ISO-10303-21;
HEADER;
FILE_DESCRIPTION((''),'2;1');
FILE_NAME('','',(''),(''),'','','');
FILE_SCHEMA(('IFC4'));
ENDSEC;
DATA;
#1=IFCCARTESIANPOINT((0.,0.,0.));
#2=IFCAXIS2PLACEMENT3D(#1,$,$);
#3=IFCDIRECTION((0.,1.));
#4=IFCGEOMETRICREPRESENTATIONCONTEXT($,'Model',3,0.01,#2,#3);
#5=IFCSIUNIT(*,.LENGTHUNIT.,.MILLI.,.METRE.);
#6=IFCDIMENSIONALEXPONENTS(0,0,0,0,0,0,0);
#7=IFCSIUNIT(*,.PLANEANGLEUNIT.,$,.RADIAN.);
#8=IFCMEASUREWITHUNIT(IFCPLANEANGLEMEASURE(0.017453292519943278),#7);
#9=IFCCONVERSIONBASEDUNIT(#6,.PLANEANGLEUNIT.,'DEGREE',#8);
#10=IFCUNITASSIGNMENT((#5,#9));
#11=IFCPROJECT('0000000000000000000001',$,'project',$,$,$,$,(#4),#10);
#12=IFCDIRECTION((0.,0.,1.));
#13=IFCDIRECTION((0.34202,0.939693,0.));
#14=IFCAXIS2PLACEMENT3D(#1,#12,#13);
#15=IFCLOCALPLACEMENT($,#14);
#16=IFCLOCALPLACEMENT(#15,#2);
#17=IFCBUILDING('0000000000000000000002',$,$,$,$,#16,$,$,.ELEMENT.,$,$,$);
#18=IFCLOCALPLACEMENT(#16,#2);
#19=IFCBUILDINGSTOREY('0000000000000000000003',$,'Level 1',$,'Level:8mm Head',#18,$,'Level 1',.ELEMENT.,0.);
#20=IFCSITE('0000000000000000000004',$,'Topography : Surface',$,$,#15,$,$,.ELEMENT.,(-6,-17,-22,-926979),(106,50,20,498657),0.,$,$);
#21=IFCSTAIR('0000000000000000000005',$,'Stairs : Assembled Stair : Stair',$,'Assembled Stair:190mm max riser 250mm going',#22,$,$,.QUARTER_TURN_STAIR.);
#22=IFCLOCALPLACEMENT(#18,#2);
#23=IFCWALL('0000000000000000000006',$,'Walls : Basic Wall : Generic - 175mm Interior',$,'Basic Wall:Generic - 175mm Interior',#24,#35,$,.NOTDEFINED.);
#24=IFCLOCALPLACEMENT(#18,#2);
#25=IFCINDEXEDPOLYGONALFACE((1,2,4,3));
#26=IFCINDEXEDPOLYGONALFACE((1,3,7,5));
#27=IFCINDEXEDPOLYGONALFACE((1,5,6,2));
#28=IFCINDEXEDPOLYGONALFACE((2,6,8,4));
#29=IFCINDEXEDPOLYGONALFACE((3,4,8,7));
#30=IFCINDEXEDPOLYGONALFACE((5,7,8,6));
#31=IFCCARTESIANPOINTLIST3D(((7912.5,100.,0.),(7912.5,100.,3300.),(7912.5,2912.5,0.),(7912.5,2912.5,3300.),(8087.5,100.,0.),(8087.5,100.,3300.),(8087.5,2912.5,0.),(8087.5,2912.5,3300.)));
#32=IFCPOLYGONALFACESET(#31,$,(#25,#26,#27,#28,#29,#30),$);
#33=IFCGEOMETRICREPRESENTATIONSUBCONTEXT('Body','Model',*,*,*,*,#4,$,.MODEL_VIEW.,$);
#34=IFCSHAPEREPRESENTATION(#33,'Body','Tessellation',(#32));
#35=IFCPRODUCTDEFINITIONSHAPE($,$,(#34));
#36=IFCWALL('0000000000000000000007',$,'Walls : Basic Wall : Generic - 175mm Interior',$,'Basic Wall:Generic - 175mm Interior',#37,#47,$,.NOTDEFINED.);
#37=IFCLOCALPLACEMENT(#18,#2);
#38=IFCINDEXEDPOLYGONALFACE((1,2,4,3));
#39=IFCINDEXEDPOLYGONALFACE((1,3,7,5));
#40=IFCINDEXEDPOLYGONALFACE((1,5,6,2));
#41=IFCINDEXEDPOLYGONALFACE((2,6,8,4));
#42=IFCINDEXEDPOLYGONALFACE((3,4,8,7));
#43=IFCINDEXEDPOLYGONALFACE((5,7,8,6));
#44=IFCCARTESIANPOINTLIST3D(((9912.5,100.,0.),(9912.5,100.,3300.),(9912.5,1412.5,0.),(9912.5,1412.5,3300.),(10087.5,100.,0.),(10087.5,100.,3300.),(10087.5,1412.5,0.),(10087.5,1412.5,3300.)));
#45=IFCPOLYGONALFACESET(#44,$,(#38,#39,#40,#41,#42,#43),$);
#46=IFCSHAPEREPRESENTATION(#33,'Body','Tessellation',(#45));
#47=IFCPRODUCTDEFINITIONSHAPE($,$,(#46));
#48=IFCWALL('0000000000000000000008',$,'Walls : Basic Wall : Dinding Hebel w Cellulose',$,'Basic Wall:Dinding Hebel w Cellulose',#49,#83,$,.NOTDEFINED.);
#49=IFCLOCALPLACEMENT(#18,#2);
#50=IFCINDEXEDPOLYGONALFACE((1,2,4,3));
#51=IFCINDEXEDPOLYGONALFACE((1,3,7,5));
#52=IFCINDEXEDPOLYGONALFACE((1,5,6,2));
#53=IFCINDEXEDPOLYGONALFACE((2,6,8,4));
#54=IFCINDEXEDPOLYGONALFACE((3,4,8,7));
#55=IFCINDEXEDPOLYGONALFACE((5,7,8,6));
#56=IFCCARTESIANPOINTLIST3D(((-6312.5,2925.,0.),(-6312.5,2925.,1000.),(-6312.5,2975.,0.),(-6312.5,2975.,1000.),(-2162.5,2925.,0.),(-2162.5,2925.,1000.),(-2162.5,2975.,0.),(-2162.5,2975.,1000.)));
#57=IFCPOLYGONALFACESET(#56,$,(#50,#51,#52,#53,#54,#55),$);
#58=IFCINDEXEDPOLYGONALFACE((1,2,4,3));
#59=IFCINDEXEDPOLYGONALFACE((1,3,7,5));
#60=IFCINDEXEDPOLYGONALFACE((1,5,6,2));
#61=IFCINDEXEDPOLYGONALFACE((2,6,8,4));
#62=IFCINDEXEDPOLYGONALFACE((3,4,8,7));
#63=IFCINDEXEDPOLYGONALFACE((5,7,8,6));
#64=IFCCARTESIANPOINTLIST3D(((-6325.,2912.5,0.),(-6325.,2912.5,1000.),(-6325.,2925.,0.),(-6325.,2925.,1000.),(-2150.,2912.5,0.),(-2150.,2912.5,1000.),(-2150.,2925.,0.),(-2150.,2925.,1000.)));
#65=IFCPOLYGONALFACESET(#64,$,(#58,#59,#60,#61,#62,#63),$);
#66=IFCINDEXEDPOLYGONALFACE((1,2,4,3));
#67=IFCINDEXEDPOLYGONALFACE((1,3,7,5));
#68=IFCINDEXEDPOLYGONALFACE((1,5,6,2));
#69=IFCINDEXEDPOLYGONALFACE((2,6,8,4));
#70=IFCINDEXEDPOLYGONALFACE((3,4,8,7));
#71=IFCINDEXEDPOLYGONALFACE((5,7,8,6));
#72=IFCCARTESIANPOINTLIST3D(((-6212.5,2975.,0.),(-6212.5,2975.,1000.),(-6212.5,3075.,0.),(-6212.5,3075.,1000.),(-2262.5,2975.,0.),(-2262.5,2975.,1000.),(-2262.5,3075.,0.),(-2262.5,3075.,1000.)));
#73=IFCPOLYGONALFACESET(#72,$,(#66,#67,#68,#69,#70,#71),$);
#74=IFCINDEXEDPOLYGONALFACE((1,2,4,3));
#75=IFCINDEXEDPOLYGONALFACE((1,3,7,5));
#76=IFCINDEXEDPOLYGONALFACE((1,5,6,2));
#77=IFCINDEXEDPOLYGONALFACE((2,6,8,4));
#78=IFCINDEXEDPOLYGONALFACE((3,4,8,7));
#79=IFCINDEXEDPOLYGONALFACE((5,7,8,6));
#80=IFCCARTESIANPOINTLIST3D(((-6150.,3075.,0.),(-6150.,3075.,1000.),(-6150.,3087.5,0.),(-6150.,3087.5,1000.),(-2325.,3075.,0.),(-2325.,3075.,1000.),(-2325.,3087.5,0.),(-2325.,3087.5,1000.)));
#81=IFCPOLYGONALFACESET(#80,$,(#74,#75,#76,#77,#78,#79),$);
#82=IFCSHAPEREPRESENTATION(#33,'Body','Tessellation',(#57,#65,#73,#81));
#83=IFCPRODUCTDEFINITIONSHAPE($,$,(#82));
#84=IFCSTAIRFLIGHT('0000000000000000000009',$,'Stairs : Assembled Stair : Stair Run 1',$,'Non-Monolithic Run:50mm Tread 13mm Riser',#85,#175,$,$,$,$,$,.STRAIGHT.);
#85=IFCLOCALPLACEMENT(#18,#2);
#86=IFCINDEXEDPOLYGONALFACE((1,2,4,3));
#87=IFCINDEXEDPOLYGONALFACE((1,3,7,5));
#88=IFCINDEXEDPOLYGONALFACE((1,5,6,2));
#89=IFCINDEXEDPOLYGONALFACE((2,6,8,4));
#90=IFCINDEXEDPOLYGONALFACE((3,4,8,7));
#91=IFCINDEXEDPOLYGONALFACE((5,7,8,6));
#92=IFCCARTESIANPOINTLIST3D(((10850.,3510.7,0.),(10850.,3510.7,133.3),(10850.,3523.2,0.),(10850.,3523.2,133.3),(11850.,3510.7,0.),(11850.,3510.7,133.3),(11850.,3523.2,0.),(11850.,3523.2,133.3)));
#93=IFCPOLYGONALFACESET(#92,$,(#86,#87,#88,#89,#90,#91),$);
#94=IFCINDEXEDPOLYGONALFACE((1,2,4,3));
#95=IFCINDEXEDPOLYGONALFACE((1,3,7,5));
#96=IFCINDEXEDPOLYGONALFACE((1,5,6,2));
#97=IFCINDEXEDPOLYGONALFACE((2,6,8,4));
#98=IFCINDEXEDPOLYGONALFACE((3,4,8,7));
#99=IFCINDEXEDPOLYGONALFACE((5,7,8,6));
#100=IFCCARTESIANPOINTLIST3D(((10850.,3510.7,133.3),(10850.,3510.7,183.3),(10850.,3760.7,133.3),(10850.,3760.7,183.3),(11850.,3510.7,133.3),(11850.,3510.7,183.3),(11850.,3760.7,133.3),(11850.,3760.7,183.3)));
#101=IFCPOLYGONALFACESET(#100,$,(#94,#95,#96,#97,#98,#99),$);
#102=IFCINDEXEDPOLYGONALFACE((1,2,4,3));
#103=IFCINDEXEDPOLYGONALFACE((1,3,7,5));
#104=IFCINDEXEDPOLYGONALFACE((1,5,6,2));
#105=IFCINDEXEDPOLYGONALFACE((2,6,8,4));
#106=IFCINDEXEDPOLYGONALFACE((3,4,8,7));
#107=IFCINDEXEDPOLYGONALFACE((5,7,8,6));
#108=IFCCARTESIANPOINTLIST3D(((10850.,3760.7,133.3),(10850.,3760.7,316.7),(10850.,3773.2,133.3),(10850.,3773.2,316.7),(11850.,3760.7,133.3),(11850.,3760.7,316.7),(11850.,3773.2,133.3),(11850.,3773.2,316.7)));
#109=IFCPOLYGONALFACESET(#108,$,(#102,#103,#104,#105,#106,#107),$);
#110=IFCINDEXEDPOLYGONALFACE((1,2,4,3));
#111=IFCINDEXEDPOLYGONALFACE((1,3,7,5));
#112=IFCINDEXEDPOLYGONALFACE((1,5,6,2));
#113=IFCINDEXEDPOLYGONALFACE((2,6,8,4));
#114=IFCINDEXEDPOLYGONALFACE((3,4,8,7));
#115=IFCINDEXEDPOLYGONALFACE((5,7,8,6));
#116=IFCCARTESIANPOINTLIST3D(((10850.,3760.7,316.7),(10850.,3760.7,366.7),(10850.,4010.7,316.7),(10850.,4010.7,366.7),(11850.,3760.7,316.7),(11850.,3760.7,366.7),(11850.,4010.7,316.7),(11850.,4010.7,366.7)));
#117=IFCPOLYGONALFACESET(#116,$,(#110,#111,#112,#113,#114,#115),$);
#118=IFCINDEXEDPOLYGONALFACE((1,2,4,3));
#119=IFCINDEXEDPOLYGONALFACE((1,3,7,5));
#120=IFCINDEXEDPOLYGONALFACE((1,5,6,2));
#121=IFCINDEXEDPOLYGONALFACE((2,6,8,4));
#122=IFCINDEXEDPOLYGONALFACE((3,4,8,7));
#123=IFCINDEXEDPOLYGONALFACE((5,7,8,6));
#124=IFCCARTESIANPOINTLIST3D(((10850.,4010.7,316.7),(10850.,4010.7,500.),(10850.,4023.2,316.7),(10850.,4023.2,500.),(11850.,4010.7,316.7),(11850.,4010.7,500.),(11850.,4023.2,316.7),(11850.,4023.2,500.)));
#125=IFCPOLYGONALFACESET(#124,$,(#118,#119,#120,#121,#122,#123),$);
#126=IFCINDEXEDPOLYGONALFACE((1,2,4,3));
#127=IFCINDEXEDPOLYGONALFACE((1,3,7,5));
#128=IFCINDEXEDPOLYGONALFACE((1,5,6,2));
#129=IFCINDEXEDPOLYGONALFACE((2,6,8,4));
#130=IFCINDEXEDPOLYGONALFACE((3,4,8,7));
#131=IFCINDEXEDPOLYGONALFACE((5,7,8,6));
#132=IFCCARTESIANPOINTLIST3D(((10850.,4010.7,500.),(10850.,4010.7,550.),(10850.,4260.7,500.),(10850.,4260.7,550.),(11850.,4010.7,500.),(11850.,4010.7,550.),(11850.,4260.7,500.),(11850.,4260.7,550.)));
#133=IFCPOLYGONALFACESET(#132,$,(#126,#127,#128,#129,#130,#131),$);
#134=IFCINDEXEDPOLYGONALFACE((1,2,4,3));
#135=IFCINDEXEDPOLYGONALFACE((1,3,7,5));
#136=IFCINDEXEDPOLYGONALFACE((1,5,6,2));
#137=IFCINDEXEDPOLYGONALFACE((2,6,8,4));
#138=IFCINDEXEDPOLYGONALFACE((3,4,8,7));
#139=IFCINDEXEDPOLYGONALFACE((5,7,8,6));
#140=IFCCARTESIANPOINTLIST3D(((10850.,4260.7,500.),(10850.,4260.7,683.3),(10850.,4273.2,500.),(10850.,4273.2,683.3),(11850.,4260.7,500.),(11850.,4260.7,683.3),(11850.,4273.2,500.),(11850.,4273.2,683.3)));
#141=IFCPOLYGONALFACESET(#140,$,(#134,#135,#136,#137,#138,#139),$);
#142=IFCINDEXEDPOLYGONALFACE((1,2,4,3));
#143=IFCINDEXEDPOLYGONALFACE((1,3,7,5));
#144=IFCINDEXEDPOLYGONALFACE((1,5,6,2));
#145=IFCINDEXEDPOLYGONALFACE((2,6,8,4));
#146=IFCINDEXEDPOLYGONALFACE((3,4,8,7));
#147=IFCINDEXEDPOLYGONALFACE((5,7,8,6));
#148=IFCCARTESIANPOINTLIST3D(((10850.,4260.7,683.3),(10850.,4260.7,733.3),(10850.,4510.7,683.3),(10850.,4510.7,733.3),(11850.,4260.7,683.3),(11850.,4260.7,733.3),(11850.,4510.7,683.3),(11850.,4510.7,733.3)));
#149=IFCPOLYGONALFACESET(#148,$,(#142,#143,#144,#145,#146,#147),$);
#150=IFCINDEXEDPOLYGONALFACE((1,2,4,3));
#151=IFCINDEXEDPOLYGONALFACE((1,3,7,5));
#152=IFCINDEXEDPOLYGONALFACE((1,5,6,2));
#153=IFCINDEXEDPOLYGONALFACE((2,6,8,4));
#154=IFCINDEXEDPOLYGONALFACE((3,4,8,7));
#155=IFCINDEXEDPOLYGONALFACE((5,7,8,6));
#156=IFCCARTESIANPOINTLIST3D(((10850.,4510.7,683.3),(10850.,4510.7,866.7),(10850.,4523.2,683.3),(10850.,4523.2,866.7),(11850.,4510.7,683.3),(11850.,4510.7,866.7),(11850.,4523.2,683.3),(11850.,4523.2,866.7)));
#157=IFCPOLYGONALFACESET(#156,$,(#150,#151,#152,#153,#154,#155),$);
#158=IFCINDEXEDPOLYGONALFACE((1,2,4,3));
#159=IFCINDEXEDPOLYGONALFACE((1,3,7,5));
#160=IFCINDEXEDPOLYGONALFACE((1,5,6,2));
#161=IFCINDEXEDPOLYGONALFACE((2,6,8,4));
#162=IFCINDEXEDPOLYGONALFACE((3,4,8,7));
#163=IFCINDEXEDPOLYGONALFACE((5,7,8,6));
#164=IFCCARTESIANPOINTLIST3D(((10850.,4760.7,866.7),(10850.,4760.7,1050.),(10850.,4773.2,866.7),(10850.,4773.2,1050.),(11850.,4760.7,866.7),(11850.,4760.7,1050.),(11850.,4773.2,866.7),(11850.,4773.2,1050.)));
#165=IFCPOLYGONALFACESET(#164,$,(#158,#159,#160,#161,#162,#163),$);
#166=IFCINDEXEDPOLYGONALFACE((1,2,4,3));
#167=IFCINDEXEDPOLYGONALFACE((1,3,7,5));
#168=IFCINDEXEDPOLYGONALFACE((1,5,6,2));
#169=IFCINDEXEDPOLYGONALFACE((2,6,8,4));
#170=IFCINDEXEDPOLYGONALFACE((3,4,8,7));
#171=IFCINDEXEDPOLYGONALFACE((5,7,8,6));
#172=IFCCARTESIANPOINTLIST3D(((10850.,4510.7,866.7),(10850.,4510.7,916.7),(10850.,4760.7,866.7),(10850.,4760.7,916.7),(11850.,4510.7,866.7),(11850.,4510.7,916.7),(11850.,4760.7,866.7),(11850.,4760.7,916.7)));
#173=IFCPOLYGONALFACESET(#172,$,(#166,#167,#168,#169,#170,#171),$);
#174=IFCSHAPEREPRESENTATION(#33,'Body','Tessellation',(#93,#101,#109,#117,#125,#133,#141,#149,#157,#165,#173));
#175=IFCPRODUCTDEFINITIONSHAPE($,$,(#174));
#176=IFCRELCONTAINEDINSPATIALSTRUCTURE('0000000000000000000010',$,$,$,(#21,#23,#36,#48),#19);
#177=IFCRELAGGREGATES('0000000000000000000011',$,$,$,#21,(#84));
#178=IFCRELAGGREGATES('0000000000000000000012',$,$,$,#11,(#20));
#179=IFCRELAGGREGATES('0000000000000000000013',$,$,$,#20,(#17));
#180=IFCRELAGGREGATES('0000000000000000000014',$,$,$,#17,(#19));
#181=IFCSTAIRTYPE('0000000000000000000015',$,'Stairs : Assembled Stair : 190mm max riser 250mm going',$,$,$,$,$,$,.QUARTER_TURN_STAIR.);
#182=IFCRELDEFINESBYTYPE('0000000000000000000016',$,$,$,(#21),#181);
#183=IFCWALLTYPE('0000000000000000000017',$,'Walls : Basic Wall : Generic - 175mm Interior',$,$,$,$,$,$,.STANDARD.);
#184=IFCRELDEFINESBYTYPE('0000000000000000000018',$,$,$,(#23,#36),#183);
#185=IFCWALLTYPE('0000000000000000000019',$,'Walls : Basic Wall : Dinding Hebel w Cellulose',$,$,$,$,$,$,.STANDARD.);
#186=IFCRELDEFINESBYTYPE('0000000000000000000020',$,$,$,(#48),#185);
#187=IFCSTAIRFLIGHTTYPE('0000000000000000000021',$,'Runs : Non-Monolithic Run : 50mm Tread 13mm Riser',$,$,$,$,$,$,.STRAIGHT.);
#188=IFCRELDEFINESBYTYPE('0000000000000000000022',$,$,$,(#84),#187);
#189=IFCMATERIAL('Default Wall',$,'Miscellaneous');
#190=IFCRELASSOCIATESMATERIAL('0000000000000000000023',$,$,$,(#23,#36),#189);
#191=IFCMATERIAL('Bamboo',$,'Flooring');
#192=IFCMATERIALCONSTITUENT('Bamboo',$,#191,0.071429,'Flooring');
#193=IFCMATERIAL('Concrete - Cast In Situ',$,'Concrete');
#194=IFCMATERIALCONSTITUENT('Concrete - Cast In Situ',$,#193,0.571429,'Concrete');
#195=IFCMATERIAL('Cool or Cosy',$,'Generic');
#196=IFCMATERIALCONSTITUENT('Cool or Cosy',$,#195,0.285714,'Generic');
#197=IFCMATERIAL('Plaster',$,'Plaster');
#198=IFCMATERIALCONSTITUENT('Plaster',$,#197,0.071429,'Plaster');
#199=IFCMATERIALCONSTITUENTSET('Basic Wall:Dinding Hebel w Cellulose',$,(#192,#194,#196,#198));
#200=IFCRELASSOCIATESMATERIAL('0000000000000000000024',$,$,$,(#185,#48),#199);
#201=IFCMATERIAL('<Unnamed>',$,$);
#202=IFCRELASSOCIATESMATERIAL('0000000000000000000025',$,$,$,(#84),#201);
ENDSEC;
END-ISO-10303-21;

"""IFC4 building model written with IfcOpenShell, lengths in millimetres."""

from ifc_helpers import new_model, entity, si_unit, converted_unit, direction, frame, origin, place, context, subcontext, project, spatial, indexed_curve, outline, extrude, material, constituent, constituent_set, type_object, element, aggregate, save


model = new_model("IFC4")

# Units and contexts
model_context = context("Model", 3, precision=0.01, world=origin(), true_north=direction((0.0, 1.0)))
body_context = subcontext(model_context, "Body", "Model", "MODEL_VIEW")
ifc_project = project(units=[si_unit("LENGTHUNIT", "METRE", prefix="MILLI"), converted_unit("PLANEANGLEUNIT", "DEGREE", entity("IfcPlaneAngleMeasure", 0.017453292519943278), si_unit("PLANEANGLEUNIT", "RADIAN"), dimensions=[0, 0, 0, 0, 0, 0, 0])], contexts=[model_context])

# Site, building, storey
site_placement = place(None, frame((0.0, 0.0, 0.0), z_axis=(0.0, 0.0, 1.0), x_axis=(0.34202, 0.939693, 0.0)))
site = spatial("IfcSite", under=ifc_project, at=site_placement, Name="Topography : Surface", CompositionType="ELEMENT", RefLatitude=(-6, -17, -22, -926979), RefLongitude=(106, 50, 20, 498657), RefElevation=0.0)
building_placement = place(site_placement, origin())
building = spatial("IfcBuilding", under=site, at=building_placement, CompositionType="ELEMENT")
storey_placement = place(building_placement, origin())
storey = spatial("IfcBuildingStorey", under=building, at=storey_placement, Name="Level 1", ObjectType="Level:8mm Head", LongName="Level 1", CompositionType="ELEMENT", Elevation=0.0)

# Shared definitions
ifc_material_1 = material(Name="<Unnamed>")
ifc_material_2 = material(Name="Bamboo", Category="Flooring")
ifc_material_3 = material(Name="Plaster", Category="Plaster")

# Stair
stair_type_1 = type_object("IfcStairType", Name="Stairs : Assembled Stair : 190mm max riser 250mm going", PredefinedType="QUARTER_TURN_STAIR")
stair_1_placement = place(storey_placement, origin())
stair_1 = element("IfcStair", 1, at=stair_1_placement, inside=storey, type_object=stair_type_1, Name="Stairs : Assembled Stair : Stair", ObjectType="Assembled Stair:190mm max riser 250mm going", PredefinedType="QUARTER_TURN_STAIR")

# Shared definitions
ifc_material_4 = material(Name="Concrete - Cast In Situ", Category="Concrete")

# Walls
ifc_material_5 = material(Name="Default Wall", Category="Miscellaneous")
wall_type_1 = type_object("IfcWallType", Name="Walls : Basic Wall : Generic - 175mm Interior", PredefinedType="STANDARD")
wall_1_placement = place(storey_placement, frame((8000.0, 2912.5, 0.0), z_axis=(0.0, 0.0, 1.0), x_axis=(0.0, -1.0, 0.0)))
element("IfcWall", 2, at=wall_1_placement, inside=storey, type_object=wall_type_1, material=ifc_material_5, Name="Walls : Basic Wall : Generic - 175mm Interior", ObjectType="Basic Wall:Generic - 175mm Interior", PredefinedType="NOTDEFINED", context=body_context, shape_type="SweptSolid", body=[
    extrude(outline(indexed_curve([(2812.5, 87.5), (0.0, 87.5), (0.0, -87.5), (2812.5, -87.5), (2812.5, 87.5)], self_intersect=False)), origin(), (0.0, 0.0, 1.0), 3300.0),
])
wall_2_placement = place(storey_placement, frame((10000.0, 1412.5, 0.0), z_axis=(0.0, 0.0, 1.0), x_axis=(0.0, -1.0, 0.0)))
element("IfcWall", 3, at=wall_2_placement, inside=storey, type_object=wall_type_1, material=ifc_material_5, Name="Walls : Basic Wall : Generic - 175mm Interior", ObjectType="Basic Wall:Generic - 175mm Interior", PredefinedType="NOTDEFINED", context=body_context, shape_type="SweptSolid", body=[
    extrude(outline(indexed_curve([(1312.5, 87.5), (0.0, 87.5), (0.0, -87.5), (1312.5, -87.5), (1312.5, 87.5)], self_intersect=False)), origin(), (0.0, 0.0, 1.0), 3300.0),
])

# Shared definitions
ifc_constituent_1 = constituent(ifc_material_2, Name="Bamboo", Category="Flooring", fraction=0.071429)
ifc_constituent_2 = constituent(ifc_material_4, Name="Concrete - Cast In Situ", Category="Concrete", fraction=0.571429)
ifc_material_6 = material(Name="Cool or Cosy", Category="Generic")
ifc_constituent_3 = constituent(ifc_material_6, Name="Cool or Cosy", Category="Generic", fraction=0.285714)
ifc_constituent_4 = constituent(ifc_material_3, Name="Plaster", Category="Plaster", fraction=0.071429)
ifc_constituent_set_1 = constituent_set(constituents=[ifc_constituent_1, ifc_constituent_2, ifc_constituent_3, ifc_constituent_4], Name="Basic Wall:Dinding Hebel w Cellulose")
wall_type_2 = type_object("IfcWallType", Name="Walls : Basic Wall : Dinding Hebel w Cellulose", PredefinedType="STANDARD", material=ifc_constituent_set_1)

# Wall
wall_3_placement = place(storey_placement, frame((-6150.0, 3000.0, 0.0)))
element("IfcWall", 4, at=wall_3_placement, inside=storey, type_object=wall_type_2, material=ifc_constituent_set_1, Name="Walls : Basic Wall : Dinding Hebel w Cellulose", ObjectType="Basic Wall:Dinding Hebel w Cellulose", PredefinedType="NOTDEFINED", context=body_context, shape_type="SweptSolid", body=[
    extrude(outline(indexed_curve([(-2075.0, -25.0), (2075.0, -25.0), (2075.0, 25.0), (-2075.0, 25.0), (-2075.0, -25.0)], self_intersect=False)), frame((1912.5, -50.0, 0.0)), (0.0, 0.0, 1.0), 1000.0),
    extrude(outline(indexed_curve([(-6.3, -2087.5), (6.2, -2087.5), (6.3, 2087.5), (-6.2, 2087.5), (-6.3, -2087.5)], self_intersect=False)), frame((1912.5, -81.2, 0.0), z_axis=(0.0, 0.0, 1.0), x_axis=(0.0, 1.0, 0.0)), (0.0, 0.0, 1.0), 1000.0),
    extrude(outline(indexed_curve([(-1975.0, -50.0), (1975.0, -50.0), (1975.0, 50.0), (-1975.0, 50.0), (-1975.0, -50.0)], self_intersect=False)), frame((1912.5, 25.0, 0.0)), (0.0, 0.0, 1.0), 1000.0),
    extrude(outline(indexed_curve([(-6.3, -1912.5), (6.2, -1912.5), (6.3, 1912.5), (-6.2, 1912.5), (-6.3, -1912.5)], self_intersect=False)), frame((1912.5, 81.2, 0.0), z_axis=(0.0, 0.0, 1.0), x_axis=(0.0, -1.0, 0.0)), (0.0, 0.0, 1.0), 1000.0),
])

# Stair flight
stair_flight_type_1 = type_object("IfcStairFlightType", Name="Runs : Non-Monolithic Run : 50mm Tread 13mm Riser", PredefinedType="STRAIGHT")
stair_flight_1_placement = place(stair_1_placement, frame((10850.0, 3510.7, 0.0)))
stair_flight_1 = element("IfcStairFlight", 5, at=stair_flight_1_placement, type_object=stair_flight_type_1, material=ifc_material_1, Name="Stairs : Assembled Stair : Stair Run 1", ObjectType="Non-Monolithic Run:50mm Tread 13mm Riser", PredefinedType="STRAIGHT", context=body_context, shape_type="SweptSolid", body=[
    extrude(outline(indexed_curve([(-500.0, -6.3), (500.0, -6.3), (500.0, 6.2), (-500.0, 6.2), (-500.0, -6.3)], self_intersect=False)), frame((500.0, 6.2, 0.0), z_axis=(0.0, 0.0, 1.0), x_axis=(-1.0, 0.0, 0.0)), (0.0, 0.0, 1.0), 133.3),
    extrude(outline(indexed_curve([(-125.0, -500.0), (125.0, -500.0), (125.0, 500.0), (-125.0, 500.0), (-125.0, -500.0)], self_intersect=False)), frame((500.0, 125.0, 133.3), z_axis=(0.0, 0.0, 1.0), x_axis=(0.0, -1.0, 0.0)), (0.0, 0.0, 1.0), 50.0),
    extrude(outline(indexed_curve([(-500.0, -6.3), (500.0, -6.3), (500.0, 6.2), (-500.0, 6.2), (-500.0, -6.3)], self_intersect=False)), frame((500.0, 256.2, 133.3), z_axis=(0.0, 0.0, 1.0), x_axis=(-1.0, 0.0, 0.0)), (0.0, 0.0, 1.0), 183.3),
    extrude(outline(indexed_curve([(-125.0, -500.0), (125.0, -500.0), (125.0, 500.0), (-125.0, 500.0), (-125.0, -500.0)], self_intersect=False)), frame((500.0, 375.0, 316.7), z_axis=(0.0, 0.0, 1.0), x_axis=(0.0, -1.0, 0.0)), (0.0, 0.0, 1.0), 50.0),
    extrude(outline(indexed_curve([(-500.0, -6.2), (500.0, -6.2), (500.0, 6.3), (-500.0, 6.3), (-500.0, -6.2)], self_intersect=False)), frame((500.0, 506.3, 316.7), z_axis=(0.0, 0.0, 1.0), x_axis=(-1.0, 0.0, 0.0)), (0.0, 0.0, 1.0), 183.3),
    extrude(outline(indexed_curve([(-125.0, -500.0), (125.0, -500.0), (125.0, 500.0), (-125.0, 500.0), (-125.0, -500.0)], self_intersect=False)), frame((500.0, 625.0, 500.0), z_axis=(0.0, 0.0, 1.0), x_axis=(0.0, -1.0, 0.0)), (0.0, 0.0, 1.0), 50.0),
    extrude(outline(indexed_curve([(-500.0, -6.3), (500.0, -6.3), (500.0, 6.2), (-500.0, 6.2), (-500.0, -6.3)], self_intersect=False)), frame((500.0, 756.2, 500.0), z_axis=(0.0, 0.0, 1.0), x_axis=(-1.0, 0.0, 0.0)), (0.0, 0.0, 1.0), 183.3),
    extrude(outline(indexed_curve([(-125.0, -500.0), (125.0, -500.0), (125.0, 500.0), (-125.0, 500.0), (-125.0, -500.0)], self_intersect=False)), frame((500.0, 875.0, 683.3), z_axis=(0.0, 0.0, 1.0), x_axis=(0.0, -1.0, 0.0)), (0.0, 0.0, 1.0), 50.0),
    extrude(outline(indexed_curve([(-500.0, -6.3), (500.0, -6.3), (500.0, 6.2), (-500.0, 6.2), (-500.0, -6.3)], self_intersect=False)), frame((500.0, 1006.2, 683.3), z_axis=(0.0, 0.0, 1.0), x_axis=(-1.0, 0.0, 0.0)), (0.0, 0.0, 1.0), 183.3),
    extrude(outline(indexed_curve([(-500.0, -6.3), (500.0, -6.3), (500.0, 6.2), (-500.0, 6.2), (-500.0, -6.3)], self_intersect=False)), frame((500.0, 1256.2, 866.7), z_axis=(0.0, 0.0, 1.0), x_axis=(-1.0, 0.0, 0.0)), (0.0, 0.0, 1.0), 183.3),
    extrude(outline(indexed_curve([(-125.0, -500.0), (125.0, -500.0), (125.0, 500.0), (-125.0, 500.0), (-125.0, -500.0)], self_intersect=False)), frame((500.0, 1125.0, 866.7), z_axis=(0.0, 0.0, 1.0), x_axis=(0.0, -1.0, 0.0)), (0.0, 0.0, 1.0), 50.0),
])
aggregate(stair_1, [stair_flight_1])

save(model, "model.ifc")
